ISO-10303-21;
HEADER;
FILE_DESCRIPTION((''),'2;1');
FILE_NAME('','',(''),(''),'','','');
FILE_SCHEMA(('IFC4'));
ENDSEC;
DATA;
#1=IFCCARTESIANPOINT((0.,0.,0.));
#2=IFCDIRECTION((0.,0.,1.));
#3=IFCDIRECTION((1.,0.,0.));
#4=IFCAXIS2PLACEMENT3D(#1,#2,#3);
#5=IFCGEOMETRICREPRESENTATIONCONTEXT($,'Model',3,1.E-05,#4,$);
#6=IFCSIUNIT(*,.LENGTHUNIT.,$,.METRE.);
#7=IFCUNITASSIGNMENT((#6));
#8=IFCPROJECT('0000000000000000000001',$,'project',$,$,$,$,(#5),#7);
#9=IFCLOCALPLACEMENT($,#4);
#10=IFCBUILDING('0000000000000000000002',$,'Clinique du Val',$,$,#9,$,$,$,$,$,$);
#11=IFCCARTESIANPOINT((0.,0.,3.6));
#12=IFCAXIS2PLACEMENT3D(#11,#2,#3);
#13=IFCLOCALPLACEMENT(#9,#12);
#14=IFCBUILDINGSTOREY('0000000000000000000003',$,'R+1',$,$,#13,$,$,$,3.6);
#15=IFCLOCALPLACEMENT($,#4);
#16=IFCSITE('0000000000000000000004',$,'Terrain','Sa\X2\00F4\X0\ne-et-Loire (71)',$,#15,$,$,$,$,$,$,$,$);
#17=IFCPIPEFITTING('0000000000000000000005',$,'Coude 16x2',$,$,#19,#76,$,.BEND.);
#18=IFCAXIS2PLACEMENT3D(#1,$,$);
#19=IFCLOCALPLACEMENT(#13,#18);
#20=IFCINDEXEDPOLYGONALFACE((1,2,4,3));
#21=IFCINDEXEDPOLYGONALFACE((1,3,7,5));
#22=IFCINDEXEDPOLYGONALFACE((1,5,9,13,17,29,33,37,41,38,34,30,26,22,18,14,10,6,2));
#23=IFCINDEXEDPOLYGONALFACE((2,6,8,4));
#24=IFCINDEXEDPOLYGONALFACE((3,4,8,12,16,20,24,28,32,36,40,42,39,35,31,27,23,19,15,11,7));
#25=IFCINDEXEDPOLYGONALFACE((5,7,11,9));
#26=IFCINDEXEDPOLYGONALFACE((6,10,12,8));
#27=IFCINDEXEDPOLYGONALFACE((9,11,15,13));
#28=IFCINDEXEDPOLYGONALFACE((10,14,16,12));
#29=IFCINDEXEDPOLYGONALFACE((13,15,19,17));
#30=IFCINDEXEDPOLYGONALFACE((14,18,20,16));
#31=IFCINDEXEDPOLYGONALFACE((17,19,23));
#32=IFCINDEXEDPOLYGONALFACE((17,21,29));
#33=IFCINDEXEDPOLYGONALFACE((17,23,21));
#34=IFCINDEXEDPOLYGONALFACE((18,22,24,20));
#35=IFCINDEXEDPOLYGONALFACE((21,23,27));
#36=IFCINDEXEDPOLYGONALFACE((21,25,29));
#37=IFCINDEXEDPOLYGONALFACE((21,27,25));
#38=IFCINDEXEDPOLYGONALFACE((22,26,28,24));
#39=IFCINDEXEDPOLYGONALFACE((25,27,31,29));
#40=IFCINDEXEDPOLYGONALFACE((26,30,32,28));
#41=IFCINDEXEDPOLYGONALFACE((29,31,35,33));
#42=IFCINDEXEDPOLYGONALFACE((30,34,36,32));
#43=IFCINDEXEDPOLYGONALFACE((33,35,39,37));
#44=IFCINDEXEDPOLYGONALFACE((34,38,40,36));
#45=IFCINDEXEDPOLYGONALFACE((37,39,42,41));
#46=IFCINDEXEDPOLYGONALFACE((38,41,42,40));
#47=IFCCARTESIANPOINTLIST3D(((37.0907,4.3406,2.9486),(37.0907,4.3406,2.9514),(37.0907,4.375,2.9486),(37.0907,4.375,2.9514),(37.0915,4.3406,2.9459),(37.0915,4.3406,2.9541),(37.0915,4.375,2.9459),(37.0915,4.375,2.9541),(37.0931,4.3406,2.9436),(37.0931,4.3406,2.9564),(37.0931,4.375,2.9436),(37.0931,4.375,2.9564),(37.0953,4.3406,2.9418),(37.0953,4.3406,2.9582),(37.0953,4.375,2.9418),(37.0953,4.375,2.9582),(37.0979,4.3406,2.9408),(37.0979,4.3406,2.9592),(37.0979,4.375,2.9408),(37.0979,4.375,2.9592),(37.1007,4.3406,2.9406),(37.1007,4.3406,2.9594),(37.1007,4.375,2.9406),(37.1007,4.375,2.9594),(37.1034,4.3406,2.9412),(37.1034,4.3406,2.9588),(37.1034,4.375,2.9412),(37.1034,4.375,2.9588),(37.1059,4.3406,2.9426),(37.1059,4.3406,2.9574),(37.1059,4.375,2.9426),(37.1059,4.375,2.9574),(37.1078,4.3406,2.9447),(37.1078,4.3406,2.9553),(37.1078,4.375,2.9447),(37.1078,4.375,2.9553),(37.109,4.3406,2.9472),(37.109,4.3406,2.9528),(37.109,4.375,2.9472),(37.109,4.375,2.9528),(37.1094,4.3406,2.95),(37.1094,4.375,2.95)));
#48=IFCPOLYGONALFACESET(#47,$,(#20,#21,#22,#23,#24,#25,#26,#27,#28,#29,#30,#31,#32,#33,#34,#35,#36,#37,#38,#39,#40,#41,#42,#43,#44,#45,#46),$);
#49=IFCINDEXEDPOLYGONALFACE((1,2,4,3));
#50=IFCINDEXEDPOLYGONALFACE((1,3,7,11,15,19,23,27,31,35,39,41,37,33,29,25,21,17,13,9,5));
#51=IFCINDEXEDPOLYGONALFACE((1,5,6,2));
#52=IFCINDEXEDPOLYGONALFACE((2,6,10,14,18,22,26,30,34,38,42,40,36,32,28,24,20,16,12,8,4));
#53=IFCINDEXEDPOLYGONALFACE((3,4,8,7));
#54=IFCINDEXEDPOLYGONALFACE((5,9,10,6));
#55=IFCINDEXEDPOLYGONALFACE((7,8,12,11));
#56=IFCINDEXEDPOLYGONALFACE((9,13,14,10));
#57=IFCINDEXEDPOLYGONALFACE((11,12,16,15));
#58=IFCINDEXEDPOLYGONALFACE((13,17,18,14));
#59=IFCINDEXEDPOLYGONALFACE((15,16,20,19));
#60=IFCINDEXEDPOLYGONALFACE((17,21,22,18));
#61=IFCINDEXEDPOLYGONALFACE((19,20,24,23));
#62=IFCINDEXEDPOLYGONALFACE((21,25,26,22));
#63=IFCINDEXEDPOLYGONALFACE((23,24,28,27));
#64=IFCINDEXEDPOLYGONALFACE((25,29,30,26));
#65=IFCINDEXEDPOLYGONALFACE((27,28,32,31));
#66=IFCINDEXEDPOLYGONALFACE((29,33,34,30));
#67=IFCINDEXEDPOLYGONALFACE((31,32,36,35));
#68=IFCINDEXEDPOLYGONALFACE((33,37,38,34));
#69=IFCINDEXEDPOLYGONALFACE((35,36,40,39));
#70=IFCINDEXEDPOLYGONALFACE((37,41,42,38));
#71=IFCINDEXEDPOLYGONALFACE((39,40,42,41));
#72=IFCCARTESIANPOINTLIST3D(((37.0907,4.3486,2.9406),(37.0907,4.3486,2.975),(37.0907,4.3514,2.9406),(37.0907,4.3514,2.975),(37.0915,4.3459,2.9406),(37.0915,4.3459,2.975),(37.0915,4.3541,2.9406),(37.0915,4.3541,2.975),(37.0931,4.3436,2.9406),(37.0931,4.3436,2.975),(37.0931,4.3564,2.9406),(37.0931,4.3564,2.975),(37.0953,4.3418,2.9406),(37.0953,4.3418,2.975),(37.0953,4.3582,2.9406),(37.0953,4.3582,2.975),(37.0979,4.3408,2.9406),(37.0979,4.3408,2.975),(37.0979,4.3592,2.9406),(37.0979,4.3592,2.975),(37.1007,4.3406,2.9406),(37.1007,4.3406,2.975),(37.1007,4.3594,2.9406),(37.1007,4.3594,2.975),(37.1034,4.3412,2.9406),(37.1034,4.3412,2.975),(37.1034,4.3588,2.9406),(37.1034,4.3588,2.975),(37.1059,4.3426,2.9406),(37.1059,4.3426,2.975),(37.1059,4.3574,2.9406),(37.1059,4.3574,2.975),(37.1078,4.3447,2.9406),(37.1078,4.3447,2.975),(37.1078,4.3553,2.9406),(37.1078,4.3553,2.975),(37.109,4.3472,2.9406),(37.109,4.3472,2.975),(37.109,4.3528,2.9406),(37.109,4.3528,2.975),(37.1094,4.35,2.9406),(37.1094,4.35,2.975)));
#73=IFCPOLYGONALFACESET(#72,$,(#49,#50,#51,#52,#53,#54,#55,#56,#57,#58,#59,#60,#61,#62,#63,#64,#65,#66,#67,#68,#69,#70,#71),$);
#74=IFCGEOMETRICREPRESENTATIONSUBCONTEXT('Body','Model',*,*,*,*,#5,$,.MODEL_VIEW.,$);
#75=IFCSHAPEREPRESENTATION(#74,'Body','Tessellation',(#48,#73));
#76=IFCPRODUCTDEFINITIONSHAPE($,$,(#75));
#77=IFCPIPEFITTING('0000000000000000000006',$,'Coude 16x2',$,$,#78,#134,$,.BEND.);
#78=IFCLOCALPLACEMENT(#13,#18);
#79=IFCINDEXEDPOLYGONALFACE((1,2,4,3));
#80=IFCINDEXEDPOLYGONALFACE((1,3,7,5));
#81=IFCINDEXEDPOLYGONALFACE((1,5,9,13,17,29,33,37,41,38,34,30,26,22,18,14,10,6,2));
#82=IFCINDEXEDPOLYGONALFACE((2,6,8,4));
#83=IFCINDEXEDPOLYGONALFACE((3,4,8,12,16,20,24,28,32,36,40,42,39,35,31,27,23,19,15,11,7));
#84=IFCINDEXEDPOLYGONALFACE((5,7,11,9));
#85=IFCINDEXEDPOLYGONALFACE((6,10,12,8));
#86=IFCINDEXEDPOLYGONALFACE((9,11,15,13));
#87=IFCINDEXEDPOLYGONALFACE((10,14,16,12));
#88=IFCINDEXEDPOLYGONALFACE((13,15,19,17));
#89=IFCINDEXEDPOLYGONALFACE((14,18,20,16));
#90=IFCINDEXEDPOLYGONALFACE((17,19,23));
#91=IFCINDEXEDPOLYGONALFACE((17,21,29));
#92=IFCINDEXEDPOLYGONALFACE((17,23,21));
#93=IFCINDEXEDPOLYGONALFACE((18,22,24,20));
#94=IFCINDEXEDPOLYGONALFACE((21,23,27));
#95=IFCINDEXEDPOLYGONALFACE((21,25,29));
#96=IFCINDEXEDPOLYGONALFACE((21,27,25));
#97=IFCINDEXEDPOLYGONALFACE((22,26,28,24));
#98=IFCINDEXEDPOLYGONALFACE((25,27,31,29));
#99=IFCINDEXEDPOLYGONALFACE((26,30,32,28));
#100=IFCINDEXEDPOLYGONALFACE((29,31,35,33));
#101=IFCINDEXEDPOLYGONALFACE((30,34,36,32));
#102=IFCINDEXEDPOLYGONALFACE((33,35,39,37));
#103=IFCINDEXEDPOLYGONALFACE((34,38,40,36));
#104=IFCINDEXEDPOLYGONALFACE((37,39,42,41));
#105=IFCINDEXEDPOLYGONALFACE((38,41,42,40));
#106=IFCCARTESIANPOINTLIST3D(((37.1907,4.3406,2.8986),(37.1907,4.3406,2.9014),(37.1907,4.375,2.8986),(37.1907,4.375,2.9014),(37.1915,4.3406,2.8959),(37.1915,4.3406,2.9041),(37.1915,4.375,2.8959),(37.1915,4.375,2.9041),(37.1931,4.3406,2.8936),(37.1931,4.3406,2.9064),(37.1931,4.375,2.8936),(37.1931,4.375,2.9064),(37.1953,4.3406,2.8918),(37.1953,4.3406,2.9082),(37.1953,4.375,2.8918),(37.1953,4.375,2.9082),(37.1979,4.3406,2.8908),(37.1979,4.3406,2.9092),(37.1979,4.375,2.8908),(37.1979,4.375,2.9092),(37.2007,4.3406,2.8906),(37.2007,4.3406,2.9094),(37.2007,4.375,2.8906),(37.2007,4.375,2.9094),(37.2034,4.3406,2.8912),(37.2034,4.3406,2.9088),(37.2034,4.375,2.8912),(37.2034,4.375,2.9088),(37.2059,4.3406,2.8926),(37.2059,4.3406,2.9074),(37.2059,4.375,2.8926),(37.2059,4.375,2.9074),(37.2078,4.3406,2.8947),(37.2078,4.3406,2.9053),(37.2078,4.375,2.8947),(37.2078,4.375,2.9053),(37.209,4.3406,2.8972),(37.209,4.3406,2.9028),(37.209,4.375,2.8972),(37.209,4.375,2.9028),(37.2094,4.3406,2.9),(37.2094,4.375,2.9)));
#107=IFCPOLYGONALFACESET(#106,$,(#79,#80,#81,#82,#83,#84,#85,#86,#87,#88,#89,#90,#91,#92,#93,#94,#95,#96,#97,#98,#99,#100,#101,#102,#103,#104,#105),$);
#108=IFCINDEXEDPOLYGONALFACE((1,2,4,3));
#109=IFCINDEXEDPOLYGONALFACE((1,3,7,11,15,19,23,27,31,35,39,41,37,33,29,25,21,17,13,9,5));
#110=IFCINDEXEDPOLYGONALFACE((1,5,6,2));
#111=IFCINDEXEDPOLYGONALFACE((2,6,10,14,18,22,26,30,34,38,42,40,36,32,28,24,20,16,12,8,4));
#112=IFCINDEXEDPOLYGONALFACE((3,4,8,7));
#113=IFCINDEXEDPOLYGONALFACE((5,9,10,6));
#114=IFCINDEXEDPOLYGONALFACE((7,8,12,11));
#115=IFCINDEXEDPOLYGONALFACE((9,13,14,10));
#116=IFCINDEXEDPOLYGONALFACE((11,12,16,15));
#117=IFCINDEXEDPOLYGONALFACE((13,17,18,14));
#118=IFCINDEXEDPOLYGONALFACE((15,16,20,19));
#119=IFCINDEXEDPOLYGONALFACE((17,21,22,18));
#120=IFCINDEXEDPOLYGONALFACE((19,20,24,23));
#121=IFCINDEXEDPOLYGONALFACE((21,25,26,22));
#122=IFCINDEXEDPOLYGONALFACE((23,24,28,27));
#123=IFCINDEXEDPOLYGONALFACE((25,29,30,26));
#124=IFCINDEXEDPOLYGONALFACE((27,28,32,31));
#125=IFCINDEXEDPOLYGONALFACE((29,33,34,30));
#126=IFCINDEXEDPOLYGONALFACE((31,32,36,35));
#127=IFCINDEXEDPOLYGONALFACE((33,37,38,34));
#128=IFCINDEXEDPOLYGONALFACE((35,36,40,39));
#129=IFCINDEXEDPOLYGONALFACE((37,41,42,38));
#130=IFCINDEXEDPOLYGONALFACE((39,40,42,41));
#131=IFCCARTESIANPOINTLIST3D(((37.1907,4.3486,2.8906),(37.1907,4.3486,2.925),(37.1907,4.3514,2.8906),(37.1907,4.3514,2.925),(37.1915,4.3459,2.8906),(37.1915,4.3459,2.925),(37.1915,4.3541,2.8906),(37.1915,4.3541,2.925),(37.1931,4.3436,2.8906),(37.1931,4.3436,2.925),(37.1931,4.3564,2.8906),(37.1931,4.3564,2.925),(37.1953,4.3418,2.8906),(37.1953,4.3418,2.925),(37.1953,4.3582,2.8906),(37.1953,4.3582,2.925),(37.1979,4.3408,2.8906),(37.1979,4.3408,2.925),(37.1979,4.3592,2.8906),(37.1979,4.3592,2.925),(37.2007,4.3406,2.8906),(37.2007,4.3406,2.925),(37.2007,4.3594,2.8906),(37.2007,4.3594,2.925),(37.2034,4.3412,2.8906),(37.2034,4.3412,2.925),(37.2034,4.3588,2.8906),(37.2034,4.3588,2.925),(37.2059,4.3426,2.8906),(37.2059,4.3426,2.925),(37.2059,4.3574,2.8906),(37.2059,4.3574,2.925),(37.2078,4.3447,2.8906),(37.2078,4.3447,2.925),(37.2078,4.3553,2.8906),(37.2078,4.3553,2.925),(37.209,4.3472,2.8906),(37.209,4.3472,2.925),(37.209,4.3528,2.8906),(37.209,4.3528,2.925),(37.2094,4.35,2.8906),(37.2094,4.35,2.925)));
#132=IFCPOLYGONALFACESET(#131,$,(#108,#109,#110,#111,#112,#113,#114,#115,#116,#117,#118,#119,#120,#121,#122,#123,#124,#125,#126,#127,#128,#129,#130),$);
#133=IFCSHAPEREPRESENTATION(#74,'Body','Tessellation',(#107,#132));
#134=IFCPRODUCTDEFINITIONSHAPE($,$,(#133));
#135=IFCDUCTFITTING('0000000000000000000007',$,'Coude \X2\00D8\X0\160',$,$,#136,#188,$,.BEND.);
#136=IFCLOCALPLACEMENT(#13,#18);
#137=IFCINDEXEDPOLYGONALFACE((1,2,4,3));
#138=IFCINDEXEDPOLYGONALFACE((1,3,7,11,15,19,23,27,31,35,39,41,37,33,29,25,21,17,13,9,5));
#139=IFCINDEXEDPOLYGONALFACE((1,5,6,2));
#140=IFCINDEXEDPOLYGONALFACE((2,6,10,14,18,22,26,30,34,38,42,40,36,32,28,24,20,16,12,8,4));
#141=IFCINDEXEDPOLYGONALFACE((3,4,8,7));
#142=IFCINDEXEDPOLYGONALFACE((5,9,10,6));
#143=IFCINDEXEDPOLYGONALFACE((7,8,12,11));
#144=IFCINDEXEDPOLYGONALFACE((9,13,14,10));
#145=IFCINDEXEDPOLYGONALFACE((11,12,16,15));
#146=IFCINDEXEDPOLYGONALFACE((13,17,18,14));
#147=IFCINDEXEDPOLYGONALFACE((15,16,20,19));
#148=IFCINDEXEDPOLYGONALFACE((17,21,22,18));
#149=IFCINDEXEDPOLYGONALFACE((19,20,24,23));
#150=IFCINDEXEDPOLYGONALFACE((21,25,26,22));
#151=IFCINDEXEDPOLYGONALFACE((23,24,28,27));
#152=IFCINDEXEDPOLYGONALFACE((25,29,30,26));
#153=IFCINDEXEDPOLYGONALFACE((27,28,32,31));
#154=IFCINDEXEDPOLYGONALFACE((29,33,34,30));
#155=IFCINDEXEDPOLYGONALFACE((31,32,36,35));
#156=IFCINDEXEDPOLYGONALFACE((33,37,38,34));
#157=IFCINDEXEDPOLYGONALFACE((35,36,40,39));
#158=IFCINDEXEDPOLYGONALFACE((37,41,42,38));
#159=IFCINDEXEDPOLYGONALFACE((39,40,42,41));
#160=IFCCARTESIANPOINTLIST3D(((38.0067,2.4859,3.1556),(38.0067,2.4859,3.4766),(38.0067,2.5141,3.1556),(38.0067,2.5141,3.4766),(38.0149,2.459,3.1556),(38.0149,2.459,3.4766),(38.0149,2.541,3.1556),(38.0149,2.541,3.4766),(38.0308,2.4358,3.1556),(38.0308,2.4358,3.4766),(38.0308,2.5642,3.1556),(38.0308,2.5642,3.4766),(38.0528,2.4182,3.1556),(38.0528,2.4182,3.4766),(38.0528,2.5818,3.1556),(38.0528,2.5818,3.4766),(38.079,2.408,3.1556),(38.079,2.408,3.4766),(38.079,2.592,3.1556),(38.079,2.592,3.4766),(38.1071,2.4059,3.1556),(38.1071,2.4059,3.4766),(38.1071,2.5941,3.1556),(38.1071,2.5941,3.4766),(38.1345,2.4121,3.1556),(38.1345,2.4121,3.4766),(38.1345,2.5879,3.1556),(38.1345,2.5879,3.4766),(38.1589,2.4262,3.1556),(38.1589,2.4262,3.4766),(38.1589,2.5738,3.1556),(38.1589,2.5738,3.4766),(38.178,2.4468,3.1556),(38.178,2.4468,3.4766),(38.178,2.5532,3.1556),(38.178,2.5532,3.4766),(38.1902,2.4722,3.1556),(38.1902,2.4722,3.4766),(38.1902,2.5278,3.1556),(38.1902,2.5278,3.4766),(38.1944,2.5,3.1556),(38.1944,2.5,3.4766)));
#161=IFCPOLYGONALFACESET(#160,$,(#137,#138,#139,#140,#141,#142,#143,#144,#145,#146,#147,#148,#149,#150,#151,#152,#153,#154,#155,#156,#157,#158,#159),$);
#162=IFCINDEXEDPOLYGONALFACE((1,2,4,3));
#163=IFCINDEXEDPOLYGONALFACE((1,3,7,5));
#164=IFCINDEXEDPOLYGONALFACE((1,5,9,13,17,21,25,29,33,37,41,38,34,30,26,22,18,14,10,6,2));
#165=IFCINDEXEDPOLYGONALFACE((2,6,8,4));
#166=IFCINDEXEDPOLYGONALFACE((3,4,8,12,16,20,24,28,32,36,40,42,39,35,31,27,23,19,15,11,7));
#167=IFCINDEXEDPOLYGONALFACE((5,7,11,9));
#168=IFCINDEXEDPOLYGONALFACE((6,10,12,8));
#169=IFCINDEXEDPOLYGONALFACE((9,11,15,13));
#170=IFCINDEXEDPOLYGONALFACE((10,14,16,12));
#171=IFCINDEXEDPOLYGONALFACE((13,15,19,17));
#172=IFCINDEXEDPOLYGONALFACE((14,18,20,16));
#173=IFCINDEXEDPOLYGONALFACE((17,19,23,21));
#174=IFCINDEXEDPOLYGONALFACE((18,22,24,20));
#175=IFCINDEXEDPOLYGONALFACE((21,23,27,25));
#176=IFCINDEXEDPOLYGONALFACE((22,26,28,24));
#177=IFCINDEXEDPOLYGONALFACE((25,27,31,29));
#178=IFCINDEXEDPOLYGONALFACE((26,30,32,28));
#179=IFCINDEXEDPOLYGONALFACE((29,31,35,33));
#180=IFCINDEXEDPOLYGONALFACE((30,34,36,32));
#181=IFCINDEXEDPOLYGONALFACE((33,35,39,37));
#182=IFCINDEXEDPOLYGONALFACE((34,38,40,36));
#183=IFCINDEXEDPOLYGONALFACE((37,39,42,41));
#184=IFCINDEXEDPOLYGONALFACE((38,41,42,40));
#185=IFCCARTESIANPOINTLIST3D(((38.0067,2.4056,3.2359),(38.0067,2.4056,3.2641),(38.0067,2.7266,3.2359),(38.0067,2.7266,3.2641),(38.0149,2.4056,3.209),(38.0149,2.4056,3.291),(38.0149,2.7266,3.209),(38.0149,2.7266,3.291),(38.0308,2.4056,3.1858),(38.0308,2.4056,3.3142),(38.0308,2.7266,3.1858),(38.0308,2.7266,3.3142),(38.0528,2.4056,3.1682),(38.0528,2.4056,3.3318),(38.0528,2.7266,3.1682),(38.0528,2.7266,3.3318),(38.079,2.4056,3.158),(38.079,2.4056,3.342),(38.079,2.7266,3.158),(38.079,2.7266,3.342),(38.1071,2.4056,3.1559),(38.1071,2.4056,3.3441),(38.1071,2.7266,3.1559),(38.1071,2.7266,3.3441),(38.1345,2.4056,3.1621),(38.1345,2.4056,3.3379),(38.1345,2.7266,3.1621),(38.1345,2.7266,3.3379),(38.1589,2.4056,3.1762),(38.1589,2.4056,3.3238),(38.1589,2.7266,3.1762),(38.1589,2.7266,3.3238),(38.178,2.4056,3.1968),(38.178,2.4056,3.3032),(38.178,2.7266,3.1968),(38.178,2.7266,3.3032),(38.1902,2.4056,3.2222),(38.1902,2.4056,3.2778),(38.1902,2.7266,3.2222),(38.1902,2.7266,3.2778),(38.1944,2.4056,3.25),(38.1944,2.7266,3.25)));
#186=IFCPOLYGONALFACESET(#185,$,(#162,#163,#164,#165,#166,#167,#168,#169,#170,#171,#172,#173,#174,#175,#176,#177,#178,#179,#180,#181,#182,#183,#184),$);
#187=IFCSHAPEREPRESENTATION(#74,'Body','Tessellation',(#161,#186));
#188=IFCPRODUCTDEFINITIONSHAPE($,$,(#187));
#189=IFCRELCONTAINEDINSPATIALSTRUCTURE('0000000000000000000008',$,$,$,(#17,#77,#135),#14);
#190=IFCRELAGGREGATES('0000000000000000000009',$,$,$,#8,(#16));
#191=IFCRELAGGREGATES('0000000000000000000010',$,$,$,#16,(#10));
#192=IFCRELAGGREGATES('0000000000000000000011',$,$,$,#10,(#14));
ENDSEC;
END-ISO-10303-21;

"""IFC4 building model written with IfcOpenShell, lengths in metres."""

from ifc_helpers import new_model, si_unit, frame, origin_with_axes, place, context, subcontext, project, spatial, circle, extrude, element, save


model = new_model("IFC4")

# Units and contexts
model_context = context("Model", 3, precision=1e-05, world=origin_with_axes())
body_context = subcontext(model_context, "Body", "Model", "MODEL_VIEW")
ifc_project = project(units=[si_unit("LENGTHUNIT", "METRE")], contexts=[model_context])

# Site, building, storey
site_placement = place(None, origin_with_axes())
site = spatial("IfcSite", under=ifc_project, at=site_placement, Name="Terrain", Description="Saône-et-Loire (71)")
building_placement = place(None, origin_with_axes())
building = spatial("IfcBuilding", under=site, at=building_placement, Name="Clinique du Val")
storey_placement = place(building_placement, frame((0.0, 0.0, 3.6), z_axis=(0.0, 0.0, 1.0), x_axis=(1.0, 0.0, 0.0)))
storey = spatial("IfcBuildingStorey", under=building, at=storey_placement, Name="R+1", Elevation=3.6)

# Pipe fittings
for number, where, z_axis, x_axis, name in (
    (1, (37.1, 4.35, 2.95), (0.0, 0.0, 1.0), (1.0, 0.0, 0.0), "Coude 16x2"),
    (2, (37.2, 4.35, 2.9), (0.0, 0.0, 1.0), (1.0, 0.0, 0.0), "Coude 16x2"),
):
    element("IfcPipeFitting", number, at=place(storey_placement, frame(where, z_axis=z_axis, x_axis=x_axis)), inside=storey, Name=name, PredefinedType="BEND", context=body_context, shape_type="SweptSolid", body=[
        extrude(circle(Radius=0.0094), frame((0.0, -0.0094, 0.0), z_axis=(0.0, 1.0, 0.0), x_axis=(1.0, 0.0, 0.0)), (0.0, 0.0, 1.0), 0.0344),
        extrude(circle(Radius=0.0094), frame((0.0, 0.0, -0.0094), z_axis=(0.0, 0.0, 1.0), x_axis=(1.0, 0.0, 0.0)), (0.0, 0.0, 1.0), 0.0344),
    ])

# Duct fitting
duct_fitting_1_placement = place(storey_placement, frame((38.1, 2.5, 3.25), z_axis=(0.0, 0.0, 1.0), x_axis=(1.0, 0.0, 0.0)))
element("IfcDuctFitting", 3, at=duct_fitting_1_placement, inside=storey, Name="Coude Ø160", PredefinedType="BEND", context=body_context, shape_type="SweptSolid", body=[
    extrude(circle(Radius=0.0944), frame((0.0, 0.0, -0.0944), z_axis=(0.0, 0.0, 1.0), x_axis=(1.0, 0.0, 0.0)), (0.0, 0.0, 1.0), 0.321),
    extrude(circle(Radius=0.0944), frame((0.0, -0.0944, 0.0), z_axis=(0.0, 1.0, 0.0), x_axis=(1.0, 0.0, 0.0)), (0.0, 0.0, 1.0), 0.321),
])

save(model, "model.ifc")
